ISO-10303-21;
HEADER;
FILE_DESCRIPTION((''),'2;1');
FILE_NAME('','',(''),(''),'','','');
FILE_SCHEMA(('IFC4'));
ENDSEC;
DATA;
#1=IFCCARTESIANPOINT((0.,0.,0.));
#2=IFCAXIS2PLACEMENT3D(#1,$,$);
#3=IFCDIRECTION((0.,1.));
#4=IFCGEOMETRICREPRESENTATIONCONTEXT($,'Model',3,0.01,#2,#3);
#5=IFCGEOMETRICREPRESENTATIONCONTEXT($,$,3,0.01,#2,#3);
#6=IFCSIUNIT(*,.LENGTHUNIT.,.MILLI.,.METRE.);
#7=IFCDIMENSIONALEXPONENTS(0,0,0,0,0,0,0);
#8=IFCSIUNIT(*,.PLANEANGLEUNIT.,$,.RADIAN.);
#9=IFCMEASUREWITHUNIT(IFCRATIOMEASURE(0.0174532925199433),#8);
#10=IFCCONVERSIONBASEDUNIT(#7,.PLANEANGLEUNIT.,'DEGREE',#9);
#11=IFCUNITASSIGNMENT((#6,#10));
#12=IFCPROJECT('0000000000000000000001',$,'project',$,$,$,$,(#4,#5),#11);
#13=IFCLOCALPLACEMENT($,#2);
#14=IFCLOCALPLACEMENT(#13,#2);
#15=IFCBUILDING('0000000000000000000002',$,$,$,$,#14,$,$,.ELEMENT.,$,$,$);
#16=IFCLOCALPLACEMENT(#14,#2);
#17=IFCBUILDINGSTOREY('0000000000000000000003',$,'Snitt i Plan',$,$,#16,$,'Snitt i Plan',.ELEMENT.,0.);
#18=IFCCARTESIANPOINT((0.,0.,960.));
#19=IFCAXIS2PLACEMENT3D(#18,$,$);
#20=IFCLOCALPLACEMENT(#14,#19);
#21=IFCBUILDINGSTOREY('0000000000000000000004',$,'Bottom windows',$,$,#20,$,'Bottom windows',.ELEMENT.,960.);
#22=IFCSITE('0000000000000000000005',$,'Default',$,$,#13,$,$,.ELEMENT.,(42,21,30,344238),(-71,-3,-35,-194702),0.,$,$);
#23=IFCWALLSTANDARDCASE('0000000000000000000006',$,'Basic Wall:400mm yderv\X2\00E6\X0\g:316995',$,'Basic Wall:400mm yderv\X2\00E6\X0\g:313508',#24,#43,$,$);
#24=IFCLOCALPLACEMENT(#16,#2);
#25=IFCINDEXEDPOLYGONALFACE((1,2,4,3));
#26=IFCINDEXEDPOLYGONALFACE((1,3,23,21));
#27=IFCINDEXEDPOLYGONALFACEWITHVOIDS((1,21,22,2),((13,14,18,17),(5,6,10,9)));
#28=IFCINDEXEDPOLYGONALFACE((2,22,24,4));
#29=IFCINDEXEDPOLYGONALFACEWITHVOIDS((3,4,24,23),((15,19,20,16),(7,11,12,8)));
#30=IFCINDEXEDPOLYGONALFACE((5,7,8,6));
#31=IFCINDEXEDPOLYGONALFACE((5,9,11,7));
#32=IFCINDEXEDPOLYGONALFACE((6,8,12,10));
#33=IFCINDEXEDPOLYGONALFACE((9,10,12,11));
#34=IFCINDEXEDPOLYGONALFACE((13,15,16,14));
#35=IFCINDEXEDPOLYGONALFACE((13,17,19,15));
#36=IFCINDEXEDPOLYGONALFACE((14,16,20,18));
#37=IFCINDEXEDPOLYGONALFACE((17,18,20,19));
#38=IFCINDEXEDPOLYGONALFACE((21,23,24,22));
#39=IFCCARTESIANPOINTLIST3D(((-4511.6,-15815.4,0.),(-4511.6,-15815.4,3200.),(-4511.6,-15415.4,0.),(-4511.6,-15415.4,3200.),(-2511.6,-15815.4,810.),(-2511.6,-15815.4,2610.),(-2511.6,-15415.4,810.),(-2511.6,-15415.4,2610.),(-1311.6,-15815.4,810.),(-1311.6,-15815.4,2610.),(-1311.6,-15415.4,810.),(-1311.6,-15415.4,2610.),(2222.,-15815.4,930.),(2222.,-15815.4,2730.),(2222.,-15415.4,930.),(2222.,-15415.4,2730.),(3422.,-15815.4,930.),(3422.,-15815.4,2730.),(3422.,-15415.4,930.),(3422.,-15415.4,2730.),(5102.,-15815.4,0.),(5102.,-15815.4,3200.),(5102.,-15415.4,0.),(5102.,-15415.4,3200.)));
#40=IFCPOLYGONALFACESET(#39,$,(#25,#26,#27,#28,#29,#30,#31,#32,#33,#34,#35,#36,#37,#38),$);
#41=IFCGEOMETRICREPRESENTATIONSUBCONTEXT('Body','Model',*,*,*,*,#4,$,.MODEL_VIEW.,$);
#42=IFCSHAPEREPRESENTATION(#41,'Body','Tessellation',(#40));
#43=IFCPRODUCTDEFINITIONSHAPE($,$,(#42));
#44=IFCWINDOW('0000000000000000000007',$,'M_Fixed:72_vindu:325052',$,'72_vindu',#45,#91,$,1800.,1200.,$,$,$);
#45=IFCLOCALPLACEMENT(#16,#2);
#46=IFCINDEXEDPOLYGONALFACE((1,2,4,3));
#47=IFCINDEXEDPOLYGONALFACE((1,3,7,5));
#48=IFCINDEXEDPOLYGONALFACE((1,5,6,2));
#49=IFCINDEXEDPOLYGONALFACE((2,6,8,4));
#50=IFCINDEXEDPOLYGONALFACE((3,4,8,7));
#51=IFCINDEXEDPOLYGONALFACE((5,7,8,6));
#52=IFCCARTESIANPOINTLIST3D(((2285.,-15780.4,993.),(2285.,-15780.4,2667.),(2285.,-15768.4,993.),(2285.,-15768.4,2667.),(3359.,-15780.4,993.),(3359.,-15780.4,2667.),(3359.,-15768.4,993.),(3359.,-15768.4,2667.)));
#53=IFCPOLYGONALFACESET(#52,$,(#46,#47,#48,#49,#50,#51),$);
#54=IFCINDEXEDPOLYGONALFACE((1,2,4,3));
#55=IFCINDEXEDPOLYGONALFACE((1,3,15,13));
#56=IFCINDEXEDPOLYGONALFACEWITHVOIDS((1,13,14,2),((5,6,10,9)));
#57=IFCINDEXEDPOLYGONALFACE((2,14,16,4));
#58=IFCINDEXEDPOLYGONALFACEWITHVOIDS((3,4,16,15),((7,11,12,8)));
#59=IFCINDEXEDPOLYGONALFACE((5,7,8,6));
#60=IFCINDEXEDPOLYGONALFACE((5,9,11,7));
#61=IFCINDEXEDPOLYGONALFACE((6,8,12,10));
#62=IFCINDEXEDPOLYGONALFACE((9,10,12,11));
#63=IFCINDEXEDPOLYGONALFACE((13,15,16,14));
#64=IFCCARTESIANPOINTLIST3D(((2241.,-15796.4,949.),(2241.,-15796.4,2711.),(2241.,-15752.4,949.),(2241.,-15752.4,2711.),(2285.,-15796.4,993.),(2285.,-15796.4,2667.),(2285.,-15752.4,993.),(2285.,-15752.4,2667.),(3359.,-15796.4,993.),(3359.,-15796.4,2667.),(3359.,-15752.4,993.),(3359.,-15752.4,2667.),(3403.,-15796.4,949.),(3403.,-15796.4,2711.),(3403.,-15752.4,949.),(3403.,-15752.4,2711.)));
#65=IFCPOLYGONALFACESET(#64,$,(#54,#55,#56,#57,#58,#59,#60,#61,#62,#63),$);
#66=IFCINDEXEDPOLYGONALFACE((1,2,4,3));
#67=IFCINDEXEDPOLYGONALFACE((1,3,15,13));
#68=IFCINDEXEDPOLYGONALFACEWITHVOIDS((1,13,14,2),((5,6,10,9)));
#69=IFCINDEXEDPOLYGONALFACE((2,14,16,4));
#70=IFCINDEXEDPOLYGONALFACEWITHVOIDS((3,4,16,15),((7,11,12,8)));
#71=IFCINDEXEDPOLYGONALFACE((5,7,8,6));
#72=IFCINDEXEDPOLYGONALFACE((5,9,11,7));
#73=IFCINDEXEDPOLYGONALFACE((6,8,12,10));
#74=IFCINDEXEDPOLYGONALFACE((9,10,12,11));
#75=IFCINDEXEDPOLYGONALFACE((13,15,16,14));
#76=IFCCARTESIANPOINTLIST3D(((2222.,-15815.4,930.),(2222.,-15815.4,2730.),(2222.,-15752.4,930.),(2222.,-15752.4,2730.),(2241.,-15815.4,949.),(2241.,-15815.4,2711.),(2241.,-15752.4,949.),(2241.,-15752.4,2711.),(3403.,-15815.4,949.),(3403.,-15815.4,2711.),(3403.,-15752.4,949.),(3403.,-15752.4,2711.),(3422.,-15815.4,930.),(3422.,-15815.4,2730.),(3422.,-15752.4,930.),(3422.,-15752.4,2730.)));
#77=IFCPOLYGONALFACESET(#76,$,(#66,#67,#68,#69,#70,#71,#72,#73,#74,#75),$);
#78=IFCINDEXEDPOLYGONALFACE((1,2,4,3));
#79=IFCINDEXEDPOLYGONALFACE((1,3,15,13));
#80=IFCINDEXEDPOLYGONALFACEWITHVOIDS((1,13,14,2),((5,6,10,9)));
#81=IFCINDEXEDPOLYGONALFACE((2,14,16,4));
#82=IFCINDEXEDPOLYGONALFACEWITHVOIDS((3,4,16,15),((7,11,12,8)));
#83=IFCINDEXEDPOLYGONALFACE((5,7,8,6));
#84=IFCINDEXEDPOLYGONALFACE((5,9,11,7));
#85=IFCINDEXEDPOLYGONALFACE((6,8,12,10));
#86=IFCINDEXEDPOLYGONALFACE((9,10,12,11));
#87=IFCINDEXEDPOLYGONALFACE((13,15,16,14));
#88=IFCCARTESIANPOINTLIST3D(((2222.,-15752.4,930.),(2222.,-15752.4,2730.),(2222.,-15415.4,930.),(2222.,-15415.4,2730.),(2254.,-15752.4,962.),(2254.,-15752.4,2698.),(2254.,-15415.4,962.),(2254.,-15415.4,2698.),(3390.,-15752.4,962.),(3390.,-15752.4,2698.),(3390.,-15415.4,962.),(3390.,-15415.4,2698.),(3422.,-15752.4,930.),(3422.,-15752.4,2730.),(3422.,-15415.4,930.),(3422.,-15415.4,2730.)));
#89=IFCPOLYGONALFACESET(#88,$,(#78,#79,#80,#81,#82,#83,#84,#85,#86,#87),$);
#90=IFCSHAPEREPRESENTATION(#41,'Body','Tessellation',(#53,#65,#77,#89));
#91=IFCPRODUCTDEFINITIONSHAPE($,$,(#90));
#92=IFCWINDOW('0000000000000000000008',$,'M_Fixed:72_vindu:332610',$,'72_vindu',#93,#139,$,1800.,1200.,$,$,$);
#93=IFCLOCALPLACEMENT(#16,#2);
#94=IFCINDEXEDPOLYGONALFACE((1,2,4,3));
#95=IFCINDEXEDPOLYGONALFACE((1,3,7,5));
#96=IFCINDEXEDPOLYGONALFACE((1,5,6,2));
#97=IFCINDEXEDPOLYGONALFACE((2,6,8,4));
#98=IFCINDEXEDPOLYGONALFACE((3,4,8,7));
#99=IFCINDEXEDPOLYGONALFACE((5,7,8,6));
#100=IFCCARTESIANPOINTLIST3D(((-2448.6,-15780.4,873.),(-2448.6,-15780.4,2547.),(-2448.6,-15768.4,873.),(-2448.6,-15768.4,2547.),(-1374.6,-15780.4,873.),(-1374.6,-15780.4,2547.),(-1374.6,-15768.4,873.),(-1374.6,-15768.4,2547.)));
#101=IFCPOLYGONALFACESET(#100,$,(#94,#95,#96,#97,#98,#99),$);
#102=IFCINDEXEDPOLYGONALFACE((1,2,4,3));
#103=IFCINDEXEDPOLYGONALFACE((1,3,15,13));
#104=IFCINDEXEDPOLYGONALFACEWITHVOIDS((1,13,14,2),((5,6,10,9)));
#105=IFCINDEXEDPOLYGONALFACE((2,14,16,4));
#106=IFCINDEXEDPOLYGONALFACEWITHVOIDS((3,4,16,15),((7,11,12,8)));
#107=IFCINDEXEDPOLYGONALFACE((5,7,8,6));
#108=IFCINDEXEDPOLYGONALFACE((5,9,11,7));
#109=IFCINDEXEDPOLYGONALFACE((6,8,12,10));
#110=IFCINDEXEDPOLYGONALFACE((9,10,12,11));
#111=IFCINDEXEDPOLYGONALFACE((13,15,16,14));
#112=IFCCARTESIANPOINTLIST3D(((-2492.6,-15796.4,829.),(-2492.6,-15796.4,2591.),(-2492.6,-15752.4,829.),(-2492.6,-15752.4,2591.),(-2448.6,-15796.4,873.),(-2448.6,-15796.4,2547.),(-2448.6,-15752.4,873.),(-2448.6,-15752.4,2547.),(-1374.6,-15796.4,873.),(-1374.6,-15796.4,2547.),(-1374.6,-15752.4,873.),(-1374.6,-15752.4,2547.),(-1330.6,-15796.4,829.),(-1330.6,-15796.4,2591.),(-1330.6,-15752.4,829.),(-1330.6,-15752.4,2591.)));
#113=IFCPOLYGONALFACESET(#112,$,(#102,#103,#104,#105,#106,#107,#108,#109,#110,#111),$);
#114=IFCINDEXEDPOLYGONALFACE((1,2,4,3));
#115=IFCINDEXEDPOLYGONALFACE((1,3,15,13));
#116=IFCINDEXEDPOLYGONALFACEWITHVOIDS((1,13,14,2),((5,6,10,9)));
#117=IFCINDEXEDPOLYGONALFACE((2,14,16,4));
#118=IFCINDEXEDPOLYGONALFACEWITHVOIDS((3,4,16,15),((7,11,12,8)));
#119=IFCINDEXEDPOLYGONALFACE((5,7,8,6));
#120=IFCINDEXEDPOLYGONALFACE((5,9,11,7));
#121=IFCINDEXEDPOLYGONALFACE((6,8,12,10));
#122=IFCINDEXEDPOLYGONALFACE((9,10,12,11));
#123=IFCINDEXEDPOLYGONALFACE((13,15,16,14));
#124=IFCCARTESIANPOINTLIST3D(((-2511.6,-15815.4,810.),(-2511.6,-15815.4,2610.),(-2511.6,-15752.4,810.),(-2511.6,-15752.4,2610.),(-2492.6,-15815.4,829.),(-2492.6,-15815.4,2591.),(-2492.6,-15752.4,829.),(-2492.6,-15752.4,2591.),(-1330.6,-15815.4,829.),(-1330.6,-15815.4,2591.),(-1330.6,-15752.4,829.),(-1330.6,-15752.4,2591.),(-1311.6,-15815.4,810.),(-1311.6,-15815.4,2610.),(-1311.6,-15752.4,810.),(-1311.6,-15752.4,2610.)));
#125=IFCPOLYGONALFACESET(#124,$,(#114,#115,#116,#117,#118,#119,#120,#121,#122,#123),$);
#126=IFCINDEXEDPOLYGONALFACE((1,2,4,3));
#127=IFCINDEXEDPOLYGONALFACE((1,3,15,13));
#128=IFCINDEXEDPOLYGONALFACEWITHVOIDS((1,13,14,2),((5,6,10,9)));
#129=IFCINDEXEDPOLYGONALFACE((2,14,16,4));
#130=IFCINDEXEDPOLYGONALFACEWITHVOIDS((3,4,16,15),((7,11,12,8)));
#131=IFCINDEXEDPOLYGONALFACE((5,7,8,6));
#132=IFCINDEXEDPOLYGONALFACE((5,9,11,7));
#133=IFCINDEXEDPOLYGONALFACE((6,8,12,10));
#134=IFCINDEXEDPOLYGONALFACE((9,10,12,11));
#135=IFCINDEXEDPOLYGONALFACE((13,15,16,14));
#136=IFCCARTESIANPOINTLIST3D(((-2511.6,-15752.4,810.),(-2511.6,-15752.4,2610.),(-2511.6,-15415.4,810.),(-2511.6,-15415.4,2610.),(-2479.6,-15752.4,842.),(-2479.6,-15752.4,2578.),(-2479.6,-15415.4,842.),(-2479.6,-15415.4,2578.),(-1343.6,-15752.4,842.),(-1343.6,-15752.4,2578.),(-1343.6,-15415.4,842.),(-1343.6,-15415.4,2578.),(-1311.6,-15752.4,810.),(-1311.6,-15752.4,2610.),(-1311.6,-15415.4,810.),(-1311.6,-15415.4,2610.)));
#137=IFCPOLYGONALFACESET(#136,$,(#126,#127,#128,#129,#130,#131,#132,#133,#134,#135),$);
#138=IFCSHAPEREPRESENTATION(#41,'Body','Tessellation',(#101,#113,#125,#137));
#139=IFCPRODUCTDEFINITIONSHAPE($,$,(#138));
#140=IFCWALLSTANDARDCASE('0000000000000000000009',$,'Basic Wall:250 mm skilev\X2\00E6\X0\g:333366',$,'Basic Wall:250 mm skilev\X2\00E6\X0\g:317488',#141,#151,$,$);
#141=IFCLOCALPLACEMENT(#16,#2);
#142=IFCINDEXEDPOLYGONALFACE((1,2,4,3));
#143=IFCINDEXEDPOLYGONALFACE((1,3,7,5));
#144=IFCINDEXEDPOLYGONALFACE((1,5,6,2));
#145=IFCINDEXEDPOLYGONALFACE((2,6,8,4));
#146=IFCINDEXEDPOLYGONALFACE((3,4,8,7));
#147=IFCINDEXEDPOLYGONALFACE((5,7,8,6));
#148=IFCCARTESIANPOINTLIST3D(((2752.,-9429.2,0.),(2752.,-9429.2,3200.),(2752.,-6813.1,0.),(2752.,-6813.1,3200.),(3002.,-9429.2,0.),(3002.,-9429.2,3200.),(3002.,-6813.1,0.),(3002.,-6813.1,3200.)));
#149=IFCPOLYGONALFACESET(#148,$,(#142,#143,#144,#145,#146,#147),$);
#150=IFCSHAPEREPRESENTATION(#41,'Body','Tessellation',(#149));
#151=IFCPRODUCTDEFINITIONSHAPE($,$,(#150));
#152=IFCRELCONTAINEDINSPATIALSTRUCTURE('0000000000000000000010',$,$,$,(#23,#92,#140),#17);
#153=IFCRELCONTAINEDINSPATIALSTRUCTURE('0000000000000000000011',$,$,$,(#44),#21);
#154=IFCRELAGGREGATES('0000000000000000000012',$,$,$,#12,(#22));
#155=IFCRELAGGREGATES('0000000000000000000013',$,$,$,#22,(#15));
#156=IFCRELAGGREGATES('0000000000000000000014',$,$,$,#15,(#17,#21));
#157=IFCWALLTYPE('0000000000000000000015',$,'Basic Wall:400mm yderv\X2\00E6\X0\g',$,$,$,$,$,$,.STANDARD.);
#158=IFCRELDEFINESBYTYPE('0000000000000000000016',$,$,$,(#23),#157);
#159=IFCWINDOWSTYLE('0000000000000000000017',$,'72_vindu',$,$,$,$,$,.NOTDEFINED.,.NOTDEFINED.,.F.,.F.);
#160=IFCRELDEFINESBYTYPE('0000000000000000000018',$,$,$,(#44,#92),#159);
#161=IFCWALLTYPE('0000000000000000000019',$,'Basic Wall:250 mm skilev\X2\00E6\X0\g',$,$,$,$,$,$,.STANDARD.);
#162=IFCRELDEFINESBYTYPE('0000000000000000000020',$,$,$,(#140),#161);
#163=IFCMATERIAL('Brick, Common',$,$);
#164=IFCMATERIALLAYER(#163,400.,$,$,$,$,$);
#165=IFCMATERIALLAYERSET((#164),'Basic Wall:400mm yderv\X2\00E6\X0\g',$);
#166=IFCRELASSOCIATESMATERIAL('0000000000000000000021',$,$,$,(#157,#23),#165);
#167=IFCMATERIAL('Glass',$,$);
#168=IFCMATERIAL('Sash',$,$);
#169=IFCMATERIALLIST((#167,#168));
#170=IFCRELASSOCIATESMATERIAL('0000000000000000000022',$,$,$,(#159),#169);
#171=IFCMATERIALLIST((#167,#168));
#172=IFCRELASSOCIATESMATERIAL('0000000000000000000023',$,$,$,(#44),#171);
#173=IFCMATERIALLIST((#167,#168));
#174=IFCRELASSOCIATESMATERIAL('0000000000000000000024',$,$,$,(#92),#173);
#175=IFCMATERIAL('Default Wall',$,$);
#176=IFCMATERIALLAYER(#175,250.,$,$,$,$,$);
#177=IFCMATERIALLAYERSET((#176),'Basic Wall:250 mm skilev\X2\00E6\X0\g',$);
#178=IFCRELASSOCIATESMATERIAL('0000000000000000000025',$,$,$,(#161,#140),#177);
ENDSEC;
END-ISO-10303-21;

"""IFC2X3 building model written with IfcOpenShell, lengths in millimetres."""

from ifc_helpers import new_model, entity, si_unit, converted_unit, direction, frame, frame_2d, origin, origin_2d_with_axis, place, context, subcontext, project, spatial, polyline, rectangle, outline, extrude, source, transform, mapped, material, material_list, layer, layer_set, layer_usage, type_object, type_shapes, element, fill, save


model = new_model("IFC2X3")

# Units and contexts
model_context = context("Model", 3, precision=0.01, world=origin(), true_north=direction((0.0, 1.0)))
context_of_model = context(None, 3, precision=0.01, world=origin(), true_north=direction((0.0, 1.0)))
body_context = subcontext(model_context, "Body", "Model", "MODEL_VIEW")
ifc_project = project(units=[si_unit("LENGTHUNIT", "METRE", prefix="MILLI"), converted_unit("PLANEANGLEUNIT", "DEGREE", entity("IfcRatioMeasure", 0.0174532925199433), si_unit("PLANEANGLEUNIT", "RADIAN"), dimensions=[0, 0, 0, 0, 0, 0, 0])], contexts=[model_context, context_of_model])

# Site, building, storey
site_placement = place(None, origin())
site = spatial("IfcSite", under=ifc_project, at=site_placement, Name="Default", CompositionType="ELEMENT", RefLatitude=(42, 21, 30, 344238), RefLongitude=(-71, -3, -35, -194702), RefElevation=0.0)
building_placement = place(site_placement, origin())
building = spatial("IfcBuilding", under=site, at=building_placement, CompositionType="ELEMENT")
storey_1_placement = place(building_placement, origin())
storey_1 = spatial("IfcBuildingStorey", under=building, at=storey_1_placement, Name="Snitt i Plan", LongName="Snitt i Plan", CompositionType="ELEMENT", Elevation=0.0)

# Shared definitions
ifc_material_1 = material(Name="Brick, Common")
ifc_layer_1 = layer(ifc_material_1, 400.0)
ifc_layer_set_1 = layer_set([ifc_layer_1], Name="Basic Wall:400mm ydervæg")
wall_type_1 = type_object("IfcWallType", Name="Basic Wall:400mm ydervæg", PredefinedType="STANDARD", material=ifc_layer_set_1)

# Shared definitions
storey_2_placement = place(building_placement, frame((0.0, 0.0, 960.0)))
storey_2 = spatial("IfcBuildingStorey", under=building, at=storey_2_placement, Name="Bottom windows", LongName="Bottom windows", CompositionType="ELEMENT", Elevation=960.0)

# Shared definitions
ifc_material_2 = material(Name="Glass")
ifc_material_3 = material(Name="Sash")
ifc_material_list_1 = material_list([ifc_material_2, ifc_material_3])
window_style_1 = type_object("IfcWindowStyle", Name="72_vindu", ConstructionType="NOTDEFINED", OperationType="NOTDEFINED", ParameterTakesPrecedence=False, Sizeable=False, material=ifc_material_list_1)
shared_shape_1 = source(origin(), body_context, "Body", "SweptSolid", [
    extrude(rectangle(XDim=12.0, YDim=1074.0, at=origin_2d_with_axis()), frame((600.0, 359.0, 63.0), z_axis=(0.0, 0.0, 1.0), x_axis=(0.0, -1.0, 0.0)), (0.0, 0.0, 1.0), 1674.0),
    extrude(outline(polyline([(-581.0, -881.0), (581.0, -881.0), (581.0, 881.0), (-581.0, 881.0), (-581.0, -881.0)]), holes=[polyline([(-537.0, -837.0), (-537.0, 837.0), (537.0, 837.0), (537.0, -837.0), (-537.0, -837.0)])]), frame((600.0, 337.0, 900.0), z_axis=(0.0, 1.0, 0.0), x_axis=(1.0, 0.0, 0.0)), (0.0, 0.0, 1.0), 44.0),
    extrude(outline(polyline([(-600.0, -900.0), (600.0, -900.0), (600.0, 900.0), (-600.0, 900.0), (-600.0, -900.0)]), holes=[polyline([(-581.0, -881.0), (-581.0, 881.0), (581.0, 881.0), (581.0, -881.0), (-581.0, -881.0)])]), frame((600.0, 337.0, 900.0), z_axis=(0.0, 1.0, 0.0), x_axis=(1.0, 0.0, 0.0)), (0.0, 0.0, 1.0), 63.0),
    extrude(outline(polyline([(-600.0, -900.0), (600.0, -900.0), (600.0, 900.0), (-600.0, 900.0), (-600.0, -900.0)]), holes=[polyline([(-568.0, -868.0), (-568.0, 868.0), (568.0, 868.0), (568.0, -868.0), (-568.0, -868.0)])]), frame((600.0, 0.0, 900.0), z_axis=(0.0, 1.0, 0.0), x_axis=(1.0, 0.0, 0.0)), (0.0, 0.0, 1.0), 337.0),
])
type_shapes(window_style_1, [shared_shape_1])

# Wall, openings, windows
ifc_layer_usage_1 = layer_usage(ifc_layer_set_1, "AXIS2", "NEGATIVE", 200.0)
wall_1_placement = place(storey_1_placement, frame((5102.0, -15615.4, 0.0), z_axis=(0.0, 0.0, 1.0), x_axis=(-1.0, 0.0, 0.0)))
wall_1 = element("IfcWallStandardCase", 1, at=wall_1_placement, inside=storey_1, type_object=wall_type_1, material=ifc_layer_usage_1, Name="Basic Wall:400mm ydervæg:316995", ObjectType="Basic Wall:400mm ydervæg:313508", context=body_context, shape_type="SweptSolid", body=[
    extrude(rectangle(XDim=9613.6, YDim=400.0, at=frame_2d((4806.8, 0.0), x_axis=(-1.0, 0.0))), origin(), (0.0, 0.0, 1.0), 3200.0),
])
opening_1_placement = place(wall_1_placement, frame((1680.0, -200.0, 930.0)))
opening_1 = element("IfcOpeningElement", 2, at=opening_1_placement, cuts=wall_1, ObjectType="Opening", context=body_context, shape_type="SweptSolid", body=[
    extrude(rectangle(XDim=1800.0, YDim=1200.0, at=frame_2d((900.0, 600.0), x_axis=(1.0, 0.0))), frame((0.0, 0.0, 0.0), z_axis=(0.0, 1.0, 0.0), x_axis=(0.0, 0.0, 1.0)), (0.0, 0.0, 1.0), 400.0),
])
opening_2_placement = place(wall_1_placement, frame((6413.6, -200.0, 810.0)))
opening_2 = element("IfcOpeningElement", 3, at=opening_2_placement, cuts=wall_1, ObjectType="Opening", context=body_context, shape_type="SweptSolid", body=[
    extrude(rectangle(XDim=1800.0, YDim=1200.0, at=frame_2d((900.0, 600.0), x_axis=(1.0, 0.0))), frame((0.0, 0.0, 0.0), z_axis=(0.0, 1.0, 0.0), x_axis=(0.0, 0.0, 1.0)), (0.0, 0.0, 1.0), 400.0),
])
ifc_material_list_2 = material_list([ifc_material_2, ifc_material_3])
window_1_placement = place(opening_1_placement, origin())
window_1 = element("IfcWindow", 4, at=window_1_placement, inside=storey_2, type_object=window_style_1, material=ifc_material_list_2, Name="M_Fixed:72_vindu:325052", ObjectType="72_vindu", OverallHeight=1800.0, OverallWidth=1200.0, context=body_context, shape_type="MappedRepresentation", body=[
    mapped(shared_shape_1, transform((0.0, 0.0, 0.0), scale=1.0)),
])
fill(opening_1, window_1)
ifc_material_list_3 = material_list([ifc_material_2, ifc_material_3])
window_2_placement = place(opening_2_placement, origin())
window_2 = element("IfcWindow", 5, at=window_2_placement, inside=storey_1, type_object=window_style_1, material=ifc_material_list_3, Name="M_Fixed:72_vindu:332610", ObjectType="72_vindu", OverallHeight=1800.0, OverallWidth=1200.0, context=body_context, shape_type="MappedRepresentation", body=[
    mapped(shared_shape_1, transform((0.0, 0.0, 0.0), scale=1.0)),
])
fill(opening_2, window_2)

# Shared definitions
ifc_material_4 = material(Name="Default Wall")
ifc_layer_2 = layer(ifc_material_4, 250.0)
ifc_layer_set_2 = layer_set([ifc_layer_2], Name="Basic Wall:250 mm skilevæg")
wall_type_2 = type_object("IfcWallType", Name="Basic Wall:250 mm skilevæg", PredefinedType="STANDARD", material=ifc_layer_set_2)

# Wall
ifc_layer_usage_2 = layer_usage(ifc_layer_set_2, "AXIS2", "NEGATIVE", 125.0)
wall_2_placement = place(storey_1_placement, frame((2877.0, -9429.2, 0.0), z_axis=(0.0, 0.0, 1.0), x_axis=(0.0, 1.0, 0.0)))
element("IfcWallStandardCase", 6, at=wall_2_placement, inside=storey_1, type_object=wall_type_2, material=ifc_layer_usage_2, Name="Basic Wall:250 mm skilevæg:333366", ObjectType="Basic Wall:250 mm skilevæg:317488", context=body_context, shape_type="SweptSolid", body=[
    extrude(rectangle(XDim=2616.1, YDim=250.0, at=frame_2d((1308.0, 0.0), x_axis=(-1.0, 0.0))), origin(), (0.0, 0.0, 1.0), 3200.0),
])

save(model, "model.ifc")
